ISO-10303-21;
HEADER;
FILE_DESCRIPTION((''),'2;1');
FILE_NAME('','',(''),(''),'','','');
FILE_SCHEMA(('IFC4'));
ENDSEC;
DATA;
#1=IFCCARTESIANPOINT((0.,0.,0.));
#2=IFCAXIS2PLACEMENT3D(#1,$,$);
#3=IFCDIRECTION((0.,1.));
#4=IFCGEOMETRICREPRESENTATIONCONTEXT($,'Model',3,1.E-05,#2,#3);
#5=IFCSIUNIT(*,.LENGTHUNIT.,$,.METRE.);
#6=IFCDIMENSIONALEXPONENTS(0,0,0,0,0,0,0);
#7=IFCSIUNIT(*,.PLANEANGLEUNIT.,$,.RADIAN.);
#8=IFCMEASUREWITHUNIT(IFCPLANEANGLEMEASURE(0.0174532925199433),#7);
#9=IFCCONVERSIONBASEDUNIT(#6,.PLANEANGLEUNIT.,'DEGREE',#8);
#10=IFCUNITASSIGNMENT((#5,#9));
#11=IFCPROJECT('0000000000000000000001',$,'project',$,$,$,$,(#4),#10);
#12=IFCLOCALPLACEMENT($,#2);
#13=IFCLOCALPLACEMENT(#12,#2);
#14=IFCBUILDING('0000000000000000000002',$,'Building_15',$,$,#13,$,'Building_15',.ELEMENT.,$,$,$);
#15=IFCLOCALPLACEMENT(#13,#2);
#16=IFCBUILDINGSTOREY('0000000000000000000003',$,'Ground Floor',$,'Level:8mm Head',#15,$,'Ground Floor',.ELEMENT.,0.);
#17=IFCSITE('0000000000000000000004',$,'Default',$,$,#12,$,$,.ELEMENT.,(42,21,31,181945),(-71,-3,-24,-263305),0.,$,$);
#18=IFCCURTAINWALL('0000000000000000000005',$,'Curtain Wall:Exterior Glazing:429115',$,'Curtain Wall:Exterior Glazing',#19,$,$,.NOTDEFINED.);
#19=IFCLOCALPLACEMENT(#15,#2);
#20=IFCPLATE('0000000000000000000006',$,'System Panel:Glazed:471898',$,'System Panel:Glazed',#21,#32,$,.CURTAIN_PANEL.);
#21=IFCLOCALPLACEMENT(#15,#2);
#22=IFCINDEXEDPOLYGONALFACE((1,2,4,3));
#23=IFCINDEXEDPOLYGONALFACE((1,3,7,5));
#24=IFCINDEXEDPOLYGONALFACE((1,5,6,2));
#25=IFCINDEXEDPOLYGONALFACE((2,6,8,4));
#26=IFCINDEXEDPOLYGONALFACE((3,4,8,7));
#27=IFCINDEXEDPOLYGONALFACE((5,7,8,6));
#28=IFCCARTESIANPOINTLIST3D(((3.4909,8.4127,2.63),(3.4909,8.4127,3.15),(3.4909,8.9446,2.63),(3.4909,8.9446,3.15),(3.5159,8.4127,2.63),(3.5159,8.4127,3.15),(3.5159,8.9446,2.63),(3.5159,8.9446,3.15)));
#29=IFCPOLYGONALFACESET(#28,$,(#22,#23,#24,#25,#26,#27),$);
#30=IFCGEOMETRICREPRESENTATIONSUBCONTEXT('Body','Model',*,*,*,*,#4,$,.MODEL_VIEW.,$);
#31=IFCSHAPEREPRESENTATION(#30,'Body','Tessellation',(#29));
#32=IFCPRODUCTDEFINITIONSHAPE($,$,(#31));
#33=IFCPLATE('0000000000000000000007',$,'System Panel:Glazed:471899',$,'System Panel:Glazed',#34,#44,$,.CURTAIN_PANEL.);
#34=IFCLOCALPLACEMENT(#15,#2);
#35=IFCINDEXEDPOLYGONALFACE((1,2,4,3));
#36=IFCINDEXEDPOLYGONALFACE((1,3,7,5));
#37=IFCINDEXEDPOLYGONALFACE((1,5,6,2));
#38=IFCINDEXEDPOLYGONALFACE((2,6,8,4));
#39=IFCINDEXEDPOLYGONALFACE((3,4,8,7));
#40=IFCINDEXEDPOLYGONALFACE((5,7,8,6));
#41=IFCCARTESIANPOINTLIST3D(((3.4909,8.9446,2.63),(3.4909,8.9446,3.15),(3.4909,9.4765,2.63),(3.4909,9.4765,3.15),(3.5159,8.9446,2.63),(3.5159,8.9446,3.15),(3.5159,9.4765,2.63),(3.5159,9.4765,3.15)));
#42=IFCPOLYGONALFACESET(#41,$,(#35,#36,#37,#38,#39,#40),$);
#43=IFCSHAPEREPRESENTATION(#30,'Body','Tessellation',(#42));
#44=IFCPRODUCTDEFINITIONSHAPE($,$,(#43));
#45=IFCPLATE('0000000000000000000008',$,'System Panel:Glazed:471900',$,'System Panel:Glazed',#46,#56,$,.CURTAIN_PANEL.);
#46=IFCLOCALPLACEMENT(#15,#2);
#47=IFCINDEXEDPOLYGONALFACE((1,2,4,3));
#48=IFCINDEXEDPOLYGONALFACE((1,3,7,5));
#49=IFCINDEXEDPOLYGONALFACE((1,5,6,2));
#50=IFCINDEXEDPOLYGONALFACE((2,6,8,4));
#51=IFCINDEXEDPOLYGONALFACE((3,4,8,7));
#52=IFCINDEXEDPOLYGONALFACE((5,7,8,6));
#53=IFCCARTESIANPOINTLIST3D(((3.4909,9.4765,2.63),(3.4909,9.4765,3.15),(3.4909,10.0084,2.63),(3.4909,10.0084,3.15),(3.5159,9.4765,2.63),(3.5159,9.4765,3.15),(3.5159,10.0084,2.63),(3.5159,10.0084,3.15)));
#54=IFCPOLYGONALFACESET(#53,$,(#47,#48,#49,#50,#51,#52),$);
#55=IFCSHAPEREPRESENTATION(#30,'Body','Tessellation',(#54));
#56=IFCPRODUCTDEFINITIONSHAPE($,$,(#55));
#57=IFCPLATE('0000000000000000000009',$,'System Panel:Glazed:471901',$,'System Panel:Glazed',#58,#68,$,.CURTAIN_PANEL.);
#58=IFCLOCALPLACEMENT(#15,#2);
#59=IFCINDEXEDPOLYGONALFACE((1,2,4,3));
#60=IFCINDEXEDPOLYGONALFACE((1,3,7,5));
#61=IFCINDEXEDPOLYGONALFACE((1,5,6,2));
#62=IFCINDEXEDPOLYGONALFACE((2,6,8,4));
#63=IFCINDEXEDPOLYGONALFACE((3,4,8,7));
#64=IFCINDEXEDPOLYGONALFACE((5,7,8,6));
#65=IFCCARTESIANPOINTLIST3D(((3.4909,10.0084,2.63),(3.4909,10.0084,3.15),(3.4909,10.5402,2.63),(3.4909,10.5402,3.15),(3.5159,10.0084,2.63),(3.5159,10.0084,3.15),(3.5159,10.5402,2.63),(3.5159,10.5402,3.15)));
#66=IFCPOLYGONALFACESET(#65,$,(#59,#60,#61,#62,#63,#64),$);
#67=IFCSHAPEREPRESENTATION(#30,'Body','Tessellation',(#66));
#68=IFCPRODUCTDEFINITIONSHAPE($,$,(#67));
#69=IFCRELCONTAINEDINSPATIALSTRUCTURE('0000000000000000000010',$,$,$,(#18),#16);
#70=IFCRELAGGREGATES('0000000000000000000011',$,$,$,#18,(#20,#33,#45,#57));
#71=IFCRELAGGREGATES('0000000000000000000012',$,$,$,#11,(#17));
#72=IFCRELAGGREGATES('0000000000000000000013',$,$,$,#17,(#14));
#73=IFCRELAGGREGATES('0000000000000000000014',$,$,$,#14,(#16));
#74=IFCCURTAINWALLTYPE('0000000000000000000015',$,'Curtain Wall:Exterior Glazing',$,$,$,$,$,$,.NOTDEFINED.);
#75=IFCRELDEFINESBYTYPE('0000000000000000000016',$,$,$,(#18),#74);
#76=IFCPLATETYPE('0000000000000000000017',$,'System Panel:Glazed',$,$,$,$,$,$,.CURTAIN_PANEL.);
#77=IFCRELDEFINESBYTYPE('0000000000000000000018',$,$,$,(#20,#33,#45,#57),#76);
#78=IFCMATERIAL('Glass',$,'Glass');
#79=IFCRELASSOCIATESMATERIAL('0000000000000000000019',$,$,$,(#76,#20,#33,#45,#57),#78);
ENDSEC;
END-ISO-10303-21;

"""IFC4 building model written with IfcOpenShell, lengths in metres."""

from ifc_helpers import new_model, entity, si_unit, converted_unit, direction, frame, origin, place, context, subcontext, project, spatial, indexed_curve, outline, extrude, source, transform, mapped, material, type_object, type_shapes, element, aggregate, save


model = new_model("IFC4")

# Units and contexts
model_context = context("Model", 3, precision=1e-05, world=origin(), true_north=direction((0.0, 1.0)))
body_context = subcontext(model_context, "Body", "Model", "MODEL_VIEW")
ifc_project = project(units=[si_unit("LENGTHUNIT", "METRE"), converted_unit("PLANEANGLEUNIT", "DEGREE", entity("IfcPlaneAngleMeasure", 0.0174532925199433), si_unit("PLANEANGLEUNIT", "RADIAN"), dimensions=[0, 0, 0, 0, 0, 0, 0])], contexts=[model_context])

# Site, building, storey
site_placement = place(None, origin())
site = spatial("IfcSite", under=ifc_project, at=site_placement, Name="Default", CompositionType="ELEMENT", RefLatitude=(42, 21, 31, 181945), RefLongitude=(-71, -3, -24, -263305), RefElevation=0.0)
building_placement = place(site_placement, origin())
building = spatial("IfcBuilding", under=site, at=building_placement, Name="Building_15", LongName="Building_15", CompositionType="ELEMENT")
storey_placement = place(building_placement, origin())
storey = spatial("IfcBuildingStorey", under=building, at=storey_placement, Name="Ground Floor", ObjectType="Level:8mm Head", LongName="Ground Floor", CompositionType="ELEMENT", Elevation=0.0)

# Curtain wall, plates
curtain_wall_type = type_object("IfcCurtainWallType", Name="Curtain Wall:Exterior Glazing", PredefinedType="NOTDEFINED")
curtain_wall_placement = place(storey_placement, origin())
curtain_wall = element("IfcCurtainWall", 1, at=curtain_wall_placement, inside=storey, type_object=curtain_wall_type, Name="Curtain Wall:Exterior Glazing:429115", ObjectType="Curtain Wall:Exterior Glazing", PredefinedType="NOTDEFINED")
ifc_material_1 = material(Name="Glass", Category="Glass")
plate_type_1 = type_object("IfcPlateType", Name="System Panel:Glazed", PredefinedType="CURTAIN_PANEL", material=ifc_material_1)
shared_shape_1 = source(origin(), body_context, "Body", "SweptSolid", [
    extrude(outline(indexed_curve([(-0.0125, -0.2659), (0.0125, -0.2659), (0.0125, 0.2659), (-0.0125, 0.2659), (-0.0125, -0.2659)], self_intersect=False)), frame((0.0, 0.037, 0.0), z_axis=(0.0, 0.0, 1.0), x_axis=(0.0, 1.0, 0.0)), (0.0, 0.0, 1.0), 0.52),
])
type_shapes(plate_type_1, [shared_shape_1])
plate_1_placement = place(curtain_wall_placement, frame((3.5404, 8.6787, 2.63), z_axis=(0.0, 0.0, 1.0), x_axis=(0.0, 1.0, 0.0)))
plate_1 = element("IfcPlate", 2, at=plate_1_placement, type_object=plate_type_1, material=ifc_material_1, Name="System Panel:Glazed:471898", ObjectType="System Panel:Glazed", PredefinedType="CURTAIN_PANEL", context=body_context, shape_type="MappedRepresentation", body=[
    mapped(shared_shape_1, transform((0.0, 0.0, 0.0), scale=1.0)),
])
plate_2_placement = place(curtain_wall_placement, frame((3.5404, 9.2106, 2.63), z_axis=(0.0, 0.0, 1.0), x_axis=(0.0, 1.0, 0.0)))
plate_2 = element("IfcPlate", 3, at=plate_2_placement, type_object=plate_type_1, material=ifc_material_1, Name="System Panel:Glazed:471899", ObjectType="System Panel:Glazed", PredefinedType="CURTAIN_PANEL", context=body_context, shape_type="MappedRepresentation", body=[
    mapped(shared_shape_1, transform((0.0, 0.0, 0.0), scale=1.0)),
])
plate_3_placement = place(curtain_wall_placement, frame((3.5404, 9.7424, 2.63), z_axis=(0.0, 0.0, 1.0), x_axis=(0.0, 1.0, 0.0)))
plate_3 = element("IfcPlate", 4, at=plate_3_placement, type_object=plate_type_1, material=ifc_material_1, Name="System Panel:Glazed:471900", ObjectType="System Panel:Glazed", PredefinedType="CURTAIN_PANEL", context=body_context, shape_type="MappedRepresentation", body=[
    mapped(shared_shape_1, transform((0.0, 0.0, 0.0), scale=1.0)),
])
plate_4_placement = place(curtain_wall_placement, frame((3.5404, 10.2743, 2.63), z_axis=(0.0, 0.0, 1.0), x_axis=(0.0, 1.0, 0.0)))
plate_4 = element("IfcPlate", 5, at=plate_4_placement, type_object=plate_type_1, material=ifc_material_1, Name="System Panel:Glazed:471901", ObjectType="System Panel:Glazed", PredefinedType="CURTAIN_PANEL", context=body_context, shape_type="MappedRepresentation", body=[
    mapped(shared_shape_1, transform((0.0, 0.0, 0.0), scale=1.0)),
])
aggregate(curtain_wall, [plate_1, plate_2, plate_3, plate_4])

save(model, "model.ifc")
